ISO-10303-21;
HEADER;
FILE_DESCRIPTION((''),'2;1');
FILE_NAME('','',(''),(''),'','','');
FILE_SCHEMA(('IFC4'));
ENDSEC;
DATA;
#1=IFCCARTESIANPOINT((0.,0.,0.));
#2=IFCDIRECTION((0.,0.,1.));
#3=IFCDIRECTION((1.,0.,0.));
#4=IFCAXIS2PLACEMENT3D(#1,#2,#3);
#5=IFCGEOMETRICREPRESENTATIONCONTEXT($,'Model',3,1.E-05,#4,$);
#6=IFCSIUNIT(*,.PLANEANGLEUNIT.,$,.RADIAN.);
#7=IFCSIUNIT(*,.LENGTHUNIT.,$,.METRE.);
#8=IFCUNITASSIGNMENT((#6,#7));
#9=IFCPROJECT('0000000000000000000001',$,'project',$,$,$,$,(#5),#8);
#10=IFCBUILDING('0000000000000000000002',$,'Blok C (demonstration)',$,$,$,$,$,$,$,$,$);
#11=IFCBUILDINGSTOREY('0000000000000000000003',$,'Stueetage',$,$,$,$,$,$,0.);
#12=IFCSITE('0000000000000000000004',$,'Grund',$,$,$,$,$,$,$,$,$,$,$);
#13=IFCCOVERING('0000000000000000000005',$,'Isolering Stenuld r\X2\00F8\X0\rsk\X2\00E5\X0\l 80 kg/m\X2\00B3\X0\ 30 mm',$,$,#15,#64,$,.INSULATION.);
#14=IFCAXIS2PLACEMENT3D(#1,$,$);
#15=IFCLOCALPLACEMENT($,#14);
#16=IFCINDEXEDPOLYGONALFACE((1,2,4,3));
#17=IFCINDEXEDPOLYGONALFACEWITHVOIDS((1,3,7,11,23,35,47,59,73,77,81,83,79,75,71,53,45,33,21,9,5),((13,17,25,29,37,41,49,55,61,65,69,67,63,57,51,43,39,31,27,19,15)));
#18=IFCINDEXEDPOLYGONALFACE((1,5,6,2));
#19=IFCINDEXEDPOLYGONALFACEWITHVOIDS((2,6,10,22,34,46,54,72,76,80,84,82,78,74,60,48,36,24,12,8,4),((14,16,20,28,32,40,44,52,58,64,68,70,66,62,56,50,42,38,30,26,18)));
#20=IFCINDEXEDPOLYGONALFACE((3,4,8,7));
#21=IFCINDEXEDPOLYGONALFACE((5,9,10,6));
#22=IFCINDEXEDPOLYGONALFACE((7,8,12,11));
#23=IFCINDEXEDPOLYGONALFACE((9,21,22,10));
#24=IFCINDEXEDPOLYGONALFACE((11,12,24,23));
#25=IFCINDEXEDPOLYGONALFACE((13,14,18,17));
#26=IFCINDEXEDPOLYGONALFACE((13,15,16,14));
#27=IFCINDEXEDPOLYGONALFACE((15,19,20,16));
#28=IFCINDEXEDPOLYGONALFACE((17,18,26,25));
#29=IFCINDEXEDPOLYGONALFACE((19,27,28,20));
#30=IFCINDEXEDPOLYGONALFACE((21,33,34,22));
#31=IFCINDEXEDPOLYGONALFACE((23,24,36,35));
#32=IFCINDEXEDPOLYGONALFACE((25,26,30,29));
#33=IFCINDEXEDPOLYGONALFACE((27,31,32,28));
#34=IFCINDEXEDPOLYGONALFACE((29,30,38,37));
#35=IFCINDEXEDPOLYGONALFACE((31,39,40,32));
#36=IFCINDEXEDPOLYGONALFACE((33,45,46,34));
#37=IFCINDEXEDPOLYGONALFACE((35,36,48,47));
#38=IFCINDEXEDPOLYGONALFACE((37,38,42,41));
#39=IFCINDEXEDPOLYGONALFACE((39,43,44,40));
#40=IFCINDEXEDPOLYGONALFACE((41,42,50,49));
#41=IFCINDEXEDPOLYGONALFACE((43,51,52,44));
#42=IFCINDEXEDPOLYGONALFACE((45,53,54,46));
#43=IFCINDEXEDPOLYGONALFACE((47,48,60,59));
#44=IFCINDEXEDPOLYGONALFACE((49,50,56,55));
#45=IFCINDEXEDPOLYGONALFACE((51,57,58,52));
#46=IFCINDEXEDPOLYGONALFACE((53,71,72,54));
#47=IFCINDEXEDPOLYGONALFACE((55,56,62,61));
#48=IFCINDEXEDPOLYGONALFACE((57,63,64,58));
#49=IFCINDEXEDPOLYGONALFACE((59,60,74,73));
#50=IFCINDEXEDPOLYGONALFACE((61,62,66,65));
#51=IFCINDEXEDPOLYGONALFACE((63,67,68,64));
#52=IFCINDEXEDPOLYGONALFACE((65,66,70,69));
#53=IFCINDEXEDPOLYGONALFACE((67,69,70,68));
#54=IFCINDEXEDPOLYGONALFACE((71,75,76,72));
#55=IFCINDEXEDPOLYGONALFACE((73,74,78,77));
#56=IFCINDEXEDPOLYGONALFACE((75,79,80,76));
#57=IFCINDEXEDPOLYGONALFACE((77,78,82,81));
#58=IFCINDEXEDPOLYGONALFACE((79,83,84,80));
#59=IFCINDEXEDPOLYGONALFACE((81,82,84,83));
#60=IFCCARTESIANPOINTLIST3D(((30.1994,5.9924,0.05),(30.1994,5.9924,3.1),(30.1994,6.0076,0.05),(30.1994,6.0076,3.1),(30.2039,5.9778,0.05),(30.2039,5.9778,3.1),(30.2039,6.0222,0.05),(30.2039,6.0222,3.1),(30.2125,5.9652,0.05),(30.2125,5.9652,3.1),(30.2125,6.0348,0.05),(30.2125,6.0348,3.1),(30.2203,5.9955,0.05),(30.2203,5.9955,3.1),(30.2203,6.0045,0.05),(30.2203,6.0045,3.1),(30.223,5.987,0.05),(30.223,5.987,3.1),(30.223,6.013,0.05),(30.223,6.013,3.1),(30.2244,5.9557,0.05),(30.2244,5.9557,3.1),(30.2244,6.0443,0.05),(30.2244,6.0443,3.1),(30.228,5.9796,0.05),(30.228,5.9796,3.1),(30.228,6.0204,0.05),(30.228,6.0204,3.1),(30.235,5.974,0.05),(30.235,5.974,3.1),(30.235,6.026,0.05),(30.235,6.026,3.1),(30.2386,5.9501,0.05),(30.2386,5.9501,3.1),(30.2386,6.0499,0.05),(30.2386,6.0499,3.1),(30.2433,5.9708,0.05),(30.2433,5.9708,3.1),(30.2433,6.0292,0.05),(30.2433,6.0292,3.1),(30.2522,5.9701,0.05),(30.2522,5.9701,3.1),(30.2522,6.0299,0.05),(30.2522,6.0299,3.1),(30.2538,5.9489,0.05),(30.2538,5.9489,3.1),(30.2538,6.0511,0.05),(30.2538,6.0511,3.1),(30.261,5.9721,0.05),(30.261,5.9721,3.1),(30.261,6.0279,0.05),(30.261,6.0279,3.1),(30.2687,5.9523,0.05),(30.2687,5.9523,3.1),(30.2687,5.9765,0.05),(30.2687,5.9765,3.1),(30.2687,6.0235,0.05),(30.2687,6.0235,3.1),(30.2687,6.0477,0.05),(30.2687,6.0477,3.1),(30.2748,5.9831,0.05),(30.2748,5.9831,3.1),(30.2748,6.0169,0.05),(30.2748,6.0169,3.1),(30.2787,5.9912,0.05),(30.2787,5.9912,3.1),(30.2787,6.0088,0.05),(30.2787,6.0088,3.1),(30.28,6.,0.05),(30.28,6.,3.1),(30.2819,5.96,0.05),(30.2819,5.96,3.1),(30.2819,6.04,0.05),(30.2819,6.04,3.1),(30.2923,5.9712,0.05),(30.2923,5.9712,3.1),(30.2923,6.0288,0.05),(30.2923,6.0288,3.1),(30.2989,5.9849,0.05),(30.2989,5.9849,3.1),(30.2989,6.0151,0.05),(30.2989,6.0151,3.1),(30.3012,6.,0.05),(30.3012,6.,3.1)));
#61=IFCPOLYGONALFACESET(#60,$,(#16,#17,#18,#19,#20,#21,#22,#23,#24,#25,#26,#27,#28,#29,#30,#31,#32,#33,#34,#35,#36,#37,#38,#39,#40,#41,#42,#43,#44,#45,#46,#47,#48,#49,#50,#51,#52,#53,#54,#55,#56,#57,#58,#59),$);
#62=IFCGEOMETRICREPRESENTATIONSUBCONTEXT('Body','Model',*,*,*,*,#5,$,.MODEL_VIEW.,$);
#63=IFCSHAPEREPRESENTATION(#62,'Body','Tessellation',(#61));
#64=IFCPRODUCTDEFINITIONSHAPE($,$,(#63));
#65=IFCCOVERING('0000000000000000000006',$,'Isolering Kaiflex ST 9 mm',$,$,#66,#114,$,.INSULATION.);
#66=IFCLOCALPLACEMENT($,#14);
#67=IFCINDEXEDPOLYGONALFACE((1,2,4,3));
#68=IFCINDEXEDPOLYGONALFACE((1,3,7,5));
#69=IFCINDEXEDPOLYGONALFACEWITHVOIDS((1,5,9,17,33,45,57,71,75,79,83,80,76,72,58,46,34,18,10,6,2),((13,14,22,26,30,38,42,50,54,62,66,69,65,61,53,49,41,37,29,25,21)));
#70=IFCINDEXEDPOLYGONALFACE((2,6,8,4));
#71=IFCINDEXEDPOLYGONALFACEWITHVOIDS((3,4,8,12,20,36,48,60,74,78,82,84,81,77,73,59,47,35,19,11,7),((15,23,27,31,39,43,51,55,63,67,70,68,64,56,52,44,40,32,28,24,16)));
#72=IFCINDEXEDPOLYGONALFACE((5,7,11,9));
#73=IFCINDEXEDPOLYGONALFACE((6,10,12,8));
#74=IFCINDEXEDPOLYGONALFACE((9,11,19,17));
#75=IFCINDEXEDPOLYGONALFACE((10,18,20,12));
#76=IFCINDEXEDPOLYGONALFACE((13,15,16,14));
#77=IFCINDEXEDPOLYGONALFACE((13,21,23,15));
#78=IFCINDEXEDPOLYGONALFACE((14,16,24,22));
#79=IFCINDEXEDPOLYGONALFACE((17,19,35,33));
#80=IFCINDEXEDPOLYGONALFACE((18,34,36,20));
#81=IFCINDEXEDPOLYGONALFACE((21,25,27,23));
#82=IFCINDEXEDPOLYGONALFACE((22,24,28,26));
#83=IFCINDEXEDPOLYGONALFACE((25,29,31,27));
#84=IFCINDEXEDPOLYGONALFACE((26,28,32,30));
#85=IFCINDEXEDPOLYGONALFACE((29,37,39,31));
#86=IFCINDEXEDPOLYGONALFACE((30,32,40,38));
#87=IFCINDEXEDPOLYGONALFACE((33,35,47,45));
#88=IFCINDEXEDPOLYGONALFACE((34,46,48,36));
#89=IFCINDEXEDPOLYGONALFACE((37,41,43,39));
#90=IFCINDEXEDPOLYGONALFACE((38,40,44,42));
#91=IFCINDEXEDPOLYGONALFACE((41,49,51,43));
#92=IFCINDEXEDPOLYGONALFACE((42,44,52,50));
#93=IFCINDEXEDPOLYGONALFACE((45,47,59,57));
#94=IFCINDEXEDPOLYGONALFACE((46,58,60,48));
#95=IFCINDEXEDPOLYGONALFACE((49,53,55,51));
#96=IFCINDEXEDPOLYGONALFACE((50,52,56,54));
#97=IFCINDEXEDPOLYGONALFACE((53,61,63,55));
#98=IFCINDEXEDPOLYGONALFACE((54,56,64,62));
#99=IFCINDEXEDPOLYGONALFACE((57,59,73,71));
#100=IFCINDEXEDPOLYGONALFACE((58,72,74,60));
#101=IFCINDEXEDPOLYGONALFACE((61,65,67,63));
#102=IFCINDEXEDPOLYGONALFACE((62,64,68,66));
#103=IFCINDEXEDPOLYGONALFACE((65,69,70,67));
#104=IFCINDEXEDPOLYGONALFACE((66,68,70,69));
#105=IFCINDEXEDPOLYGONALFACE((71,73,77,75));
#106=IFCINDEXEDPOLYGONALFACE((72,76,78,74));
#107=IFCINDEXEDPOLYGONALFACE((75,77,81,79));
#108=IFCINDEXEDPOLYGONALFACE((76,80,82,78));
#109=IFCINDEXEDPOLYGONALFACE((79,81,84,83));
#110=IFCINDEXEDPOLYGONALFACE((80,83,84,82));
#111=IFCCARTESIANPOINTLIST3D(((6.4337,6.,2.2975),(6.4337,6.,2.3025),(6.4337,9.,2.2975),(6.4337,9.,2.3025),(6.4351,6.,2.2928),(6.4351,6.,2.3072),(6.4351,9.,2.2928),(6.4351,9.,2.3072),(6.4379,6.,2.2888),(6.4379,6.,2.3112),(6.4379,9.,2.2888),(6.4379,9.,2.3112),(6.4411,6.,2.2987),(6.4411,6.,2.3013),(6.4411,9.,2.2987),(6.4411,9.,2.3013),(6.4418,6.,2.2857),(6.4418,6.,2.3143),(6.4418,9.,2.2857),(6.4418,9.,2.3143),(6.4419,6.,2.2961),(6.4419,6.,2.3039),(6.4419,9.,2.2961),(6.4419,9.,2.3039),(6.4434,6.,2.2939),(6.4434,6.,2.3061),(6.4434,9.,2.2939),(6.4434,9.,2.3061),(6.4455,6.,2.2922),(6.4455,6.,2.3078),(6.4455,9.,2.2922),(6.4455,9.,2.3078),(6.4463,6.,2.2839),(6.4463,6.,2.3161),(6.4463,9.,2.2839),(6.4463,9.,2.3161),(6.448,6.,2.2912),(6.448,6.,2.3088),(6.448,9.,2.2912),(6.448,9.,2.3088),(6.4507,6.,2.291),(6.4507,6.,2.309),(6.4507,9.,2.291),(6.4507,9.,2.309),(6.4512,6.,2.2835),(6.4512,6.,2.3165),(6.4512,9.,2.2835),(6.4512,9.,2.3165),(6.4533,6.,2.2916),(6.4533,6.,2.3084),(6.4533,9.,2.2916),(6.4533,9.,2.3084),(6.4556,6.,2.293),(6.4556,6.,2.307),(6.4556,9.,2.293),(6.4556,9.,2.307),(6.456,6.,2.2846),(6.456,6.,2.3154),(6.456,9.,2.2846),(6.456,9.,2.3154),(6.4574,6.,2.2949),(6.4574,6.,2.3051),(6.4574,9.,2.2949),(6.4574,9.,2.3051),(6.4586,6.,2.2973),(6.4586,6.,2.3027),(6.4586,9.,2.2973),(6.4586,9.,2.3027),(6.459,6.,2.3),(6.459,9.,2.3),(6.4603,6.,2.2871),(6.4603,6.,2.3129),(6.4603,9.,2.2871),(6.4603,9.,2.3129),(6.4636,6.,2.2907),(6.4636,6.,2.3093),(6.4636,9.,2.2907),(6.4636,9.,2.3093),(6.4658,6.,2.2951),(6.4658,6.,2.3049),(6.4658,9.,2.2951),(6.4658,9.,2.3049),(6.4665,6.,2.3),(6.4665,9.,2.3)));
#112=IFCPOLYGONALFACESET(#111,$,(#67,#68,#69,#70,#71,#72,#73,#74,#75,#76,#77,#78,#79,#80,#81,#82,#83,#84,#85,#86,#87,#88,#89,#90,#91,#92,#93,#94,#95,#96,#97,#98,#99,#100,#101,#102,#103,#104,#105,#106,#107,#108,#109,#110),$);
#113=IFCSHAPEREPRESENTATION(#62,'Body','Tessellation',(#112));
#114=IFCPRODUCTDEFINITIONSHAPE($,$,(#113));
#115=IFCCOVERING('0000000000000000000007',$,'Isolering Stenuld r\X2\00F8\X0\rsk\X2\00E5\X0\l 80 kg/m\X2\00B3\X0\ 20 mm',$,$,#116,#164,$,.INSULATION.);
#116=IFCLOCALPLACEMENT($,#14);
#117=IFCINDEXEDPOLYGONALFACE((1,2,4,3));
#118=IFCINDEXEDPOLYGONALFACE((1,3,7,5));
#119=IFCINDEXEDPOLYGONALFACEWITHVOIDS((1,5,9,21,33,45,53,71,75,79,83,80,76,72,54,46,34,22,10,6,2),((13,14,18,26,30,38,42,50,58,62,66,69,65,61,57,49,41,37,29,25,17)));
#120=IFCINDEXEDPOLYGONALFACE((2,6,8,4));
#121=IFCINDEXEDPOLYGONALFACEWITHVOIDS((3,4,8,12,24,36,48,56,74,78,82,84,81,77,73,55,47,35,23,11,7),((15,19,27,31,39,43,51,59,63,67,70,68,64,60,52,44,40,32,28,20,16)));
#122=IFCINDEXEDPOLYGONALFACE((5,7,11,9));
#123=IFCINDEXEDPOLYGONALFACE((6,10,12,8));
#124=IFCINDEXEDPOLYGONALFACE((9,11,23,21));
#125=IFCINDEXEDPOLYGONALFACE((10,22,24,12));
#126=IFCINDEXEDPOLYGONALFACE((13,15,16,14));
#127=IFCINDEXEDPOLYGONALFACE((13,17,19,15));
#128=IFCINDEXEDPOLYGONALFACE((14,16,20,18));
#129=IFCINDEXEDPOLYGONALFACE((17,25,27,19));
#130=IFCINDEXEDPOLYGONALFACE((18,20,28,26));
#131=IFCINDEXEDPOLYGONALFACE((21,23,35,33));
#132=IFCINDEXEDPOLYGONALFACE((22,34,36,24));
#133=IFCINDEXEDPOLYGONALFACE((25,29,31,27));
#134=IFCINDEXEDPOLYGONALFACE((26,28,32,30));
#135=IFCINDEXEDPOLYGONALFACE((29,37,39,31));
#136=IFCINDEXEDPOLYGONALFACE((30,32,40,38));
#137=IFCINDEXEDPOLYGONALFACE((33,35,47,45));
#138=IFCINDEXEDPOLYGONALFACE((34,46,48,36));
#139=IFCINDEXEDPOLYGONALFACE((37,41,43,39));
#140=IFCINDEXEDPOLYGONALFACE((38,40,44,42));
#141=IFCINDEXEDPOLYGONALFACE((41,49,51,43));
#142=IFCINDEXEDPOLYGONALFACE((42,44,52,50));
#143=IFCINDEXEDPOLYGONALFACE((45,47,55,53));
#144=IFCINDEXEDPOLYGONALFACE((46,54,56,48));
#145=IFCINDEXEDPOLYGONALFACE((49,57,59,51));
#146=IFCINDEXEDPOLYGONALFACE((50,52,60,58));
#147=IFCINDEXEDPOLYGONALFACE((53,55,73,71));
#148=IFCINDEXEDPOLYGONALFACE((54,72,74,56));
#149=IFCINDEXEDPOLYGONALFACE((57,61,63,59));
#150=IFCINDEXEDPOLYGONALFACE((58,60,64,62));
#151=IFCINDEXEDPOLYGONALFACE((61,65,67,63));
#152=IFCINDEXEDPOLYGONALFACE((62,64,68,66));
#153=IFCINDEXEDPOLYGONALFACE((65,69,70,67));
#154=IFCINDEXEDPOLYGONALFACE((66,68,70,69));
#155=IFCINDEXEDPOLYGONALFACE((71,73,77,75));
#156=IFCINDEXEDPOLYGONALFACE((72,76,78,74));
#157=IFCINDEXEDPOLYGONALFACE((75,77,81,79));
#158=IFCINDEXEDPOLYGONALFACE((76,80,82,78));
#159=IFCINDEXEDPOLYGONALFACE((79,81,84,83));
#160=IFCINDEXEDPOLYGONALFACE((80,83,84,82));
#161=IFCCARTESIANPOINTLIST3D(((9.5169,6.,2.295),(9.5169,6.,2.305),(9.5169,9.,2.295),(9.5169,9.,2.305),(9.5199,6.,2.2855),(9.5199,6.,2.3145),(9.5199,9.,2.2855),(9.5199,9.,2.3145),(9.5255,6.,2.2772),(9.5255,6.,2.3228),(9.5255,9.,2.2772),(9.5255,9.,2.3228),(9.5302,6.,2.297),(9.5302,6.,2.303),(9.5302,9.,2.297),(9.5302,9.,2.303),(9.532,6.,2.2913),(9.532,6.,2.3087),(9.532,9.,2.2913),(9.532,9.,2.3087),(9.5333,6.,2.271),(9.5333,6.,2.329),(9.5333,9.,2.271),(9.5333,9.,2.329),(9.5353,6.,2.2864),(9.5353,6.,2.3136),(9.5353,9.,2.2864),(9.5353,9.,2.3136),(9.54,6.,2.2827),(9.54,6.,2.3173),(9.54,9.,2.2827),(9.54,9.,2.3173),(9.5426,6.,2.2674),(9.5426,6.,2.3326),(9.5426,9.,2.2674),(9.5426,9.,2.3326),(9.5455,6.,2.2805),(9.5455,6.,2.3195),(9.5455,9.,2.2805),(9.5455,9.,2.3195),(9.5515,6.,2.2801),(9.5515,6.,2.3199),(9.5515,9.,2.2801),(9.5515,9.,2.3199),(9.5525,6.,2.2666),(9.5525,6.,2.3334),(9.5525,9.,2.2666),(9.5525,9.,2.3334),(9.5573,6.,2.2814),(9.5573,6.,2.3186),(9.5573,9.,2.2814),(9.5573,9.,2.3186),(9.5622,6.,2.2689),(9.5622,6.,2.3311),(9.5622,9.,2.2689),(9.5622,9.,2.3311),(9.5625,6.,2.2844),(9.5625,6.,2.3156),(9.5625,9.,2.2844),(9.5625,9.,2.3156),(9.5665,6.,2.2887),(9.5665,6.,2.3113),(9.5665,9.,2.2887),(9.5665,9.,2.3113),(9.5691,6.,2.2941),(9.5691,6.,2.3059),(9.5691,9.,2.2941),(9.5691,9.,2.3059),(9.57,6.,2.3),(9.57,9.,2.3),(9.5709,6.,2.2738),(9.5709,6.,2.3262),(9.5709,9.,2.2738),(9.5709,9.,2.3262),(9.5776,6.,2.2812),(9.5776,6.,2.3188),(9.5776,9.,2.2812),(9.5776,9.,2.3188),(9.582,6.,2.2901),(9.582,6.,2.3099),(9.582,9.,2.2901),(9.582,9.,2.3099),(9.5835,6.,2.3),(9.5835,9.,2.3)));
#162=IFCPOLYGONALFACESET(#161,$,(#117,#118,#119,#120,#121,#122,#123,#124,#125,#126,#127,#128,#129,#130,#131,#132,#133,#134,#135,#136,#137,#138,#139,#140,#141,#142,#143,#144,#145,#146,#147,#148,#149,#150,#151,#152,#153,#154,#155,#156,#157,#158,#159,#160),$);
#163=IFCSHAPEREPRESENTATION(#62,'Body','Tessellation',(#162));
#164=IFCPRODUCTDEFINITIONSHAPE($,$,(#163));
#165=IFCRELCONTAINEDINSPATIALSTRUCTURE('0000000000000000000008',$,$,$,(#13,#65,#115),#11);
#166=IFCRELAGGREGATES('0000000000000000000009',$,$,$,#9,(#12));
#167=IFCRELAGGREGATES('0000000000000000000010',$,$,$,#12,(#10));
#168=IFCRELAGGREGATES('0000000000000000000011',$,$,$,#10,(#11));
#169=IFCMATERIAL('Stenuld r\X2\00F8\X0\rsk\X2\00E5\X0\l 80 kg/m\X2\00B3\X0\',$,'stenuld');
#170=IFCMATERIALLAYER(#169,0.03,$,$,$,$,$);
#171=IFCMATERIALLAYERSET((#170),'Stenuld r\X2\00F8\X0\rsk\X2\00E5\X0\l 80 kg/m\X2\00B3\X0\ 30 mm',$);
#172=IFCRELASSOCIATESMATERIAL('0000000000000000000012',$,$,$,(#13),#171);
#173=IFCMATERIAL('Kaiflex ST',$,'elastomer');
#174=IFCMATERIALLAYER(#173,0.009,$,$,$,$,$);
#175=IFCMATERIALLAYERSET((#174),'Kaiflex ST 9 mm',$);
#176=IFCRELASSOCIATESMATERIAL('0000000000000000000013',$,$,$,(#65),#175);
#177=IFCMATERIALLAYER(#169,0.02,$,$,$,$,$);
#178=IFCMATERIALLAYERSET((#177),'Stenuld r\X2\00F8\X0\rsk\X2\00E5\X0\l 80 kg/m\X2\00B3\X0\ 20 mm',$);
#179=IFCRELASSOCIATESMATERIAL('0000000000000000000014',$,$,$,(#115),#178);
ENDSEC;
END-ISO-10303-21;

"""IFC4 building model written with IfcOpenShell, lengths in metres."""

from ifc_helpers import new_model, si_unit, frame, origin_with_axes, place, context, subcontext, project, spatial, hollow_circle, extrude, material, layer, layer_set, element, save


model = new_model("IFC4")

# Units and contexts
model_context = context("Model", 3, precision=1e-05, world=origin_with_axes())
body_context = subcontext(model_context, "Body", "Model", "MODEL_VIEW")
ifc_project = project(units=[si_unit("PLANEANGLEUNIT", "RADIAN"), si_unit("LENGTHUNIT", "METRE")], contexts=[model_context])

# Site, building, storey
site = spatial("IfcSite", under=ifc_project, Name="Grund")
building = spatial("IfcBuilding", under=site, Name="Blok C (demonstration)")
storey = spatial("IfcBuildingStorey", under=building, Name="Stueetage", Elevation=0.0)

# Coverings
ifc_material_1 = material(Name="Stenuld rørskål 80 kg/m³", Category="stenuld")
ifc_material_2 = material(Name="Kaiflex ST", Category="elastomer")
ifc_layer_1 = layer(ifc_material_1, 0.03)
ifc_layer_set_1 = layer_set([ifc_layer_1], Name="Stenuld rørskål 80 kg/m³ 30 mm")
covering_1_placement = place(None, origin_with_axes())
element("IfcCovering", 1, at=covering_1_placement, inside=storey, material=ifc_layer_set_1, Name="Isolering Stenuld rørskål 80 kg/m³ 30 mm", PredefinedType="INSULATION", context=body_context, shape_type="SweptSolid", body=[
    extrude(hollow_circle(Radius=0.0512, WallThickness=0.0212), frame((30.25, 6.0, 0.05), z_axis=(0.0, 0.0, 1.0), x_axis=(1.0, 0.0, 0.0)), (0.0, 0.0, 1.0), 3.05),
])
ifc_layer_2 = layer(ifc_material_2, 0.009)
ifc_layer_set_2 = layer_set([ifc_layer_2], Name="Kaiflex ST 9 mm")
covering_2_placement = place(None, origin_with_axes())
element("IfcCovering", 2, at=covering_2_placement, inside=storey, material=ifc_layer_set_2, Name="Isolering Kaiflex ST 9 mm", PredefinedType="INSULATION", context=body_context, shape_type="SweptSolid", body=[
    extrude(hollow_circle(Radius=0.0165, WallThickness=0.0075), frame((6.45, 6.0, 2.3), z_axis=(0.0, 1.0, 0.0), x_axis=(1.0, 0.0, 0.0)), (0.0, 0.0, 1.0), 3.0),
])
ifc_layer_3 = layer(ifc_material_1, 0.02)
ifc_layer_set_3 = layer_set([ifc_layer_3], Name="Stenuld rørskål 80 kg/m³ 20 mm")
covering_3_placement = place(None, origin_with_axes())
element("IfcCovering", 3, at=covering_3_placement, inside=storey, material=ifc_layer_set_3, Name="Isolering Stenuld rørskål 80 kg/m³ 20 mm", PredefinedType="INSULATION", context=body_context, shape_type="SweptSolid", body=[
    extrude(hollow_circle(Radius=0.0335, WallThickness=0.0135), frame((9.55, 6.0, 2.3), z_axis=(0.0, 1.0, 0.0), x_axis=(1.0, 0.0, 0.0)), (0.0, 0.0, 1.0), 3.0),
])

save(model, "model.ifc")
